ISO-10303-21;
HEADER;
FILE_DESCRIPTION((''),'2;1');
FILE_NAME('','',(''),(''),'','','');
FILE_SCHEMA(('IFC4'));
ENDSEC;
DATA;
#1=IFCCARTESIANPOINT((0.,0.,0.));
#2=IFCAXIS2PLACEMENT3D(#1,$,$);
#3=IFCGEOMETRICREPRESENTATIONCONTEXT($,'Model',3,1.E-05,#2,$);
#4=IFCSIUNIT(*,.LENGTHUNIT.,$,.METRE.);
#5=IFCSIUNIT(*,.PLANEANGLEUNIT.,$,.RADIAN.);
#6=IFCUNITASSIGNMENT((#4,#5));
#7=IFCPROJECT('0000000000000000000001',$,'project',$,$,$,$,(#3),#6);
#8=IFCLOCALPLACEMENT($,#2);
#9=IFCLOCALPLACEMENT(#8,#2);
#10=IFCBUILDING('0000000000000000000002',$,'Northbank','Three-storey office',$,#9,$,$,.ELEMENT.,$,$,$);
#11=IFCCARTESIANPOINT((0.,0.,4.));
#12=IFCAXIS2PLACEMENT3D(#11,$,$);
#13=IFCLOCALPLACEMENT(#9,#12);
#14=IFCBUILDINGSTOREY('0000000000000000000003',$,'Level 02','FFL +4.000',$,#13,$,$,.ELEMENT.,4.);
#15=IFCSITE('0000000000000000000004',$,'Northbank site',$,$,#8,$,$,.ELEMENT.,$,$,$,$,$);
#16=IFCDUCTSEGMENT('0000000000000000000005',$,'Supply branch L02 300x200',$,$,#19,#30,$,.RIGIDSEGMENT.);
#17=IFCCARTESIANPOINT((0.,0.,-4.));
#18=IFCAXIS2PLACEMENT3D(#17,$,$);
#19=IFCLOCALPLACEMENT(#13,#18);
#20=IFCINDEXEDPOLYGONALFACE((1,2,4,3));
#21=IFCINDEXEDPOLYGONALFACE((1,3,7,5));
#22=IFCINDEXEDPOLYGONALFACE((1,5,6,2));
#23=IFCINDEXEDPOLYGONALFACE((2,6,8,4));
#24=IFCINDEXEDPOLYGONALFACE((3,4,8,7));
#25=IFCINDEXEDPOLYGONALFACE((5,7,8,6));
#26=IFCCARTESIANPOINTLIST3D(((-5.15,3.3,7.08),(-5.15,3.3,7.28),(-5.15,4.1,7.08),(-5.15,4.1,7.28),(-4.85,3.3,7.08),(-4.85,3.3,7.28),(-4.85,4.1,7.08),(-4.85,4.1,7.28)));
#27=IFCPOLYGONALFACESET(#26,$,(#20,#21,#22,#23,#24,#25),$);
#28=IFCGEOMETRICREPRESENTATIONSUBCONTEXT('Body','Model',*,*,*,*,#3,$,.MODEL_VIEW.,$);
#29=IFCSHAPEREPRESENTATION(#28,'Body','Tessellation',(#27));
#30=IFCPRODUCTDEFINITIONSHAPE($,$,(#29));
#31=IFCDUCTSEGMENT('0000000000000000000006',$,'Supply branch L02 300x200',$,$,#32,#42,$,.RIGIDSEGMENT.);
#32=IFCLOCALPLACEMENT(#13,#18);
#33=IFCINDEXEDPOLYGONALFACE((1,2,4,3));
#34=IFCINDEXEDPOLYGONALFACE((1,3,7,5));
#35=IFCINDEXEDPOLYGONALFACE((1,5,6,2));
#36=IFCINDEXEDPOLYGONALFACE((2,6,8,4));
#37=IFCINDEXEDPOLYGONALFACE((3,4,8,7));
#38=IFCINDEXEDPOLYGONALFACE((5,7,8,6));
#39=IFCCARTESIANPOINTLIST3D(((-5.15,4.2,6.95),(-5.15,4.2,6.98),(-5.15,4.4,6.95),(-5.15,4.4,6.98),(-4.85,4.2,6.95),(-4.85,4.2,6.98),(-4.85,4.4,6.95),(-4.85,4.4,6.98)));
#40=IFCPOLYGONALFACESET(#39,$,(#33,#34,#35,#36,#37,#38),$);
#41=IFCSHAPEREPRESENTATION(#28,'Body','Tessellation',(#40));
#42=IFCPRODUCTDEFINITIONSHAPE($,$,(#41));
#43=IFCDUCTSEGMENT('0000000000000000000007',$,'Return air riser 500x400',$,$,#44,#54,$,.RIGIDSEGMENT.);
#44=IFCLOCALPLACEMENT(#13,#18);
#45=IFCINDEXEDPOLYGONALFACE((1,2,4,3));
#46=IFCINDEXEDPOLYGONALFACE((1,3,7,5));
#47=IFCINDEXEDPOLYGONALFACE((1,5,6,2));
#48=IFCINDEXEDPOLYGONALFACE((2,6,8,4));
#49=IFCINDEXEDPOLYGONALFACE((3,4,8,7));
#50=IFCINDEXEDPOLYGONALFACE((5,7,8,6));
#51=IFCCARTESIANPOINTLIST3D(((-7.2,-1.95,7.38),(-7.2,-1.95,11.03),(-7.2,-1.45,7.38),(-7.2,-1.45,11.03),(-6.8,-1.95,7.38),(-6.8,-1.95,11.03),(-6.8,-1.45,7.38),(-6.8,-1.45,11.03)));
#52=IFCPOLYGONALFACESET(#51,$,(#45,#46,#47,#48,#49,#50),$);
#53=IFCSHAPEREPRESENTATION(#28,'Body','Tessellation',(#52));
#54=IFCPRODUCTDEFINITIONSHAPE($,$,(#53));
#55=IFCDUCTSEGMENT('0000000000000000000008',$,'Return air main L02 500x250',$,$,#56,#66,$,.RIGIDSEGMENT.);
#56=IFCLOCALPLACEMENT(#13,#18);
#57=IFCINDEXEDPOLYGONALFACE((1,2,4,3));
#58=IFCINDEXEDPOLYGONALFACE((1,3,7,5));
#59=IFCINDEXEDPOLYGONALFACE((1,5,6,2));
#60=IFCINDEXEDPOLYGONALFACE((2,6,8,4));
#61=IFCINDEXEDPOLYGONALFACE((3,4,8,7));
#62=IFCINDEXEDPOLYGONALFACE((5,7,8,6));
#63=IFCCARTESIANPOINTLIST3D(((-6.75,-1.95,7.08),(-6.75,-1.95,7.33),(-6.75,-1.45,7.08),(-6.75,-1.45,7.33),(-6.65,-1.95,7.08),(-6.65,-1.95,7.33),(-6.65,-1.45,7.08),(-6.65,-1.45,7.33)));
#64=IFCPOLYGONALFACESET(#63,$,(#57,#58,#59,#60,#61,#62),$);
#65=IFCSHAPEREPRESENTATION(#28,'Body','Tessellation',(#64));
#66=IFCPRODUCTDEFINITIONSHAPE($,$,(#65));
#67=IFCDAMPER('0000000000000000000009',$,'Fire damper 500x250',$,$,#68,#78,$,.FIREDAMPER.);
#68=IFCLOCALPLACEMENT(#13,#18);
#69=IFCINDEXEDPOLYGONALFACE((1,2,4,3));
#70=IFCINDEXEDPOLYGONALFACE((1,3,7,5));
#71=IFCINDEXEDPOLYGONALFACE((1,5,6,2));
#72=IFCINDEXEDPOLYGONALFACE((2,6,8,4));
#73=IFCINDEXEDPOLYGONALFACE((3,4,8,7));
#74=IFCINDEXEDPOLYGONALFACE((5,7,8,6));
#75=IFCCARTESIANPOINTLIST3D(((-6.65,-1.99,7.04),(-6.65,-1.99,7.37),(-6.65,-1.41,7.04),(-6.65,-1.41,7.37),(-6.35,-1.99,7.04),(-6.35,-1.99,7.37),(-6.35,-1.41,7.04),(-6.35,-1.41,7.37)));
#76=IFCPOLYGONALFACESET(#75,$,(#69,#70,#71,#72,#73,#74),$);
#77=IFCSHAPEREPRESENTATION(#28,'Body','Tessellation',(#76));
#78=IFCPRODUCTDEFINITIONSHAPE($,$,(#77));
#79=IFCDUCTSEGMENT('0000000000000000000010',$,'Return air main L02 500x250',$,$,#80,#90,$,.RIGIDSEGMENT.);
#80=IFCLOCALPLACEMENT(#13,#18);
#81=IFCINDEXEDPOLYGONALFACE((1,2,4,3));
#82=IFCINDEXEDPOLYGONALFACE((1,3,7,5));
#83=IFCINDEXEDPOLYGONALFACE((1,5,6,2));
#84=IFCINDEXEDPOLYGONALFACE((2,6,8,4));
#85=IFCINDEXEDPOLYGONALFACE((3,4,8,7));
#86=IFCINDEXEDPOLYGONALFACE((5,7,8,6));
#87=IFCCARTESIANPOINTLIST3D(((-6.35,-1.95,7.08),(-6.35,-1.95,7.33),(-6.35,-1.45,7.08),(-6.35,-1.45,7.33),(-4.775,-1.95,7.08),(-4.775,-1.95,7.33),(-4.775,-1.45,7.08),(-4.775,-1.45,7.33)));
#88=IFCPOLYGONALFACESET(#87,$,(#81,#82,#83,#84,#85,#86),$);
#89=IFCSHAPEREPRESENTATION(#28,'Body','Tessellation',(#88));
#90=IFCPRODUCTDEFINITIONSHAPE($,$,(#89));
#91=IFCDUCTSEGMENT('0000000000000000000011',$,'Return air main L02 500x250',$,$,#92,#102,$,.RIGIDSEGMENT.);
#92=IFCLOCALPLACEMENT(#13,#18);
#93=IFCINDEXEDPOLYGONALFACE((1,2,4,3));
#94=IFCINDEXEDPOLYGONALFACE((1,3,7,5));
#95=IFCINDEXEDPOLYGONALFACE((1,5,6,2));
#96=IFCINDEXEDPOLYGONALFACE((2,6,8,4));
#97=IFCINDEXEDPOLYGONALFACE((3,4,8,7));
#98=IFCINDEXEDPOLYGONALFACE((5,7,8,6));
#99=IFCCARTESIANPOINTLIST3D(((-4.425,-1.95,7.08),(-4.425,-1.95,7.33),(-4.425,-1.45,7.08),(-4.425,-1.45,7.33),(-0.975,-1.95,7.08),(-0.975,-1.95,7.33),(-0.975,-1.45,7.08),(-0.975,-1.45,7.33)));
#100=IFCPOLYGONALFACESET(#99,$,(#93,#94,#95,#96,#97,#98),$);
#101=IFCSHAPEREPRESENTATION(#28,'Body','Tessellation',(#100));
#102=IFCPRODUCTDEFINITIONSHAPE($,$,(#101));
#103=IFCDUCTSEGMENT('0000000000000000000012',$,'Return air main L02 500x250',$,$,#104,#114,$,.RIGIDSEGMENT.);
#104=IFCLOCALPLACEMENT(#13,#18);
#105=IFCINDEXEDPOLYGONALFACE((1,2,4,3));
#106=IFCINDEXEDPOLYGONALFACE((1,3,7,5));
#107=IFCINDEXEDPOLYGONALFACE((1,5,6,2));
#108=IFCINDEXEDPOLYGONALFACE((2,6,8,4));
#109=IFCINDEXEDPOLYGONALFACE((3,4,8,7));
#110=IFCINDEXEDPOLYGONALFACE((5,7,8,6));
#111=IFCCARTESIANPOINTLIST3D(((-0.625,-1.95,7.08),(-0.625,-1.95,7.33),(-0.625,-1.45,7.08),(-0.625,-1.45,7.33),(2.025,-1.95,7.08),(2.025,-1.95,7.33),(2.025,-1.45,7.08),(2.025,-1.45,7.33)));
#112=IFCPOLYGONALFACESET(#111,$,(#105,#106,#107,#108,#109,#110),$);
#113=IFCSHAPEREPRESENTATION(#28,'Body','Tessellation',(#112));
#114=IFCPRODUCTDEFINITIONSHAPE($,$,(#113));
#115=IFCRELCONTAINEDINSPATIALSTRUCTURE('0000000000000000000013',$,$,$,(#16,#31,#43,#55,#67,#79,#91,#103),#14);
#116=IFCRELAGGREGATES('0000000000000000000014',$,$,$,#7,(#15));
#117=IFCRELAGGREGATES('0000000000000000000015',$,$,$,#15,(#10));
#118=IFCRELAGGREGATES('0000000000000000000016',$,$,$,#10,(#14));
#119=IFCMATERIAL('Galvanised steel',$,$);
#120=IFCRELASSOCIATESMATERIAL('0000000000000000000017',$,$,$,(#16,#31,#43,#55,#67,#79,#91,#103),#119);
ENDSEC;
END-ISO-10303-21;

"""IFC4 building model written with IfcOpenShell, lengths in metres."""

from ifc_helpers import new_model, si_unit, frame, origin, place, context, subcontext, project, spatial, rectangle, extrude, material, element, save


model = new_model("IFC4")

# Units and contexts
model_context = context("Model", 3, precision=1e-05, world=origin())
body_context = subcontext(model_context, "Body", "Model", "MODEL_VIEW")
ifc_project = project(units=[si_unit("LENGTHUNIT", "METRE"), si_unit("PLANEANGLEUNIT", "RADIAN")], contexts=[model_context])

# Site, building, storey
site_placement = place(None, origin())
site = spatial("IfcSite", under=ifc_project, at=site_placement, Name="Northbank site", CompositionType="ELEMENT")
building_placement = place(site_placement, origin())
building = spatial("IfcBuilding", under=site, at=building_placement, Name="Northbank", Description="Three-storey office", CompositionType="ELEMENT")
storey_placement = place(building_placement, frame((0.0, 0.0, 4.0)))
storey = spatial("IfcBuildingStorey", under=building, at=storey_placement, Name="Level 02", Description="FFL +4.000", CompositionType="ELEMENT", Elevation=4.0)

# Shared definitions
ifc_material_1 = material(Name="Galvanised steel")

# Duct segments
duct_segment_1_placement = place(storey_placement, frame((0.0, 0.0, -4.0)))
element("IfcDuctSegment", 1, at=duct_segment_1_placement, inside=storey, material=ifc_material_1, Name="Supply branch L02 300x200", PredefinedType="RIGIDSEGMENT", context=body_context, shape_type="SweptSolid", body=[
    extrude(rectangle(XDim=0.3, YDim=0.2), frame((-5.0, 3.3, 7.18), z_axis=(0.0, 1.0, 0.0), x_axis=(-1.0, 0.0, 0.0)), (0.0, 0.0, 1.0), 0.8),
])
duct_segment_2_placement = place(storey_placement, frame((0.0, 0.0, -4.0)))
element("IfcDuctSegment", 2, at=duct_segment_2_placement, inside=storey, material=ifc_material_1, Name="Supply branch L02 300x200", PredefinedType="RIGIDSEGMENT", context=body_context, shape_type="SweptSolid", body=[
    extrude(rectangle(XDim=0.3, YDim=0.2), frame((-5.0, 4.3, 6.98), z_axis=(0.0, 0.0, -1.0), x_axis=(-1.0, 0.0, 0.0)), (0.0, 0.0, 1.0), 0.03),
])

# Duct segments
duct_segment_3_placement = place(storey_placement, frame((0.0, 0.0, -4.0)))
element("IfcDuctSegment", 3, at=duct_segment_3_placement, inside=storey, material=ifc_material_1, Name="Return air riser 500x400", PredefinedType="RIGIDSEGMENT", context=body_context, shape_type="SweptSolid", body=[
    extrude(rectangle(XDim=0.5, YDim=0.4), frame((-7.0, -1.7, 11.03), z_axis=(0.0, 0.0, -1.0), x_axis=(0.0, -1.0, 0.0)), (0.0, 0.0, 1.0), 3.65),
])
duct_segment_4_placement = place(storey_placement, frame((0.0, 0.0, -4.0)))
element("IfcDuctSegment", 4, at=duct_segment_4_placement, inside=storey, material=ifc_material_1, Name="Return air main L02 500x250", PredefinedType="RIGIDSEGMENT", context=body_context, shape_type="SweptSolid", body=[
    extrude(rectangle(XDim=0.5, YDim=0.25), frame((-6.75, -1.7, 7.205), z_axis=(1.0, 0.0, 0.0), x_axis=(0.0, 1.0, 0.0)), (0.0, 0.0, 1.0), 0.1),
])

# Damper
damper_1_placement = place(storey_placement, frame((0.0, 0.0, -4.0)))
element("IfcDamper", 5, at=damper_1_placement, inside=storey, material=ifc_material_1, Name="Fire damper 500x250", PredefinedType="FIREDAMPER", context=body_context, shape_type="SweptSolid", body=[
    extrude(rectangle(XDim=0.58, YDim=0.33), frame((-6.65, -1.7, 7.205), z_axis=(1.0, 0.0, 0.0), x_axis=(0.0, 1.0, 0.0)), (0.0, 0.0, 1.0), 0.3),
])

# Duct segment
duct_segment_5_placement = place(storey_placement, frame((0.0, 0.0, -4.0)))
element("IfcDuctSegment", 6, at=duct_segment_5_placement, inside=storey, material=ifc_material_1, Name="Return air main L02 500x250", PredefinedType="RIGIDSEGMENT", context=body_context, shape_type="SweptSolid", body=[
    extrude(rectangle(XDim=0.5, YDim=0.25), frame((-6.35, -1.7, 7.205), z_axis=(1.0, 0.0, 0.0), x_axis=(0.0, 1.0, 0.0)), (0.0, 0.0, 1.0), 1.575),
])

# Duct segment
duct_segment_6_placement = place(storey_placement, frame((0.0, 0.0, -4.0)))
element("IfcDuctSegment", 7, at=duct_segment_6_placement, inside=storey, material=ifc_material_1, Name="Return air main L02 500x250", PredefinedType="RIGIDSEGMENT", context=body_context, shape_type="SweptSolid", body=[
    extrude(rectangle(XDim=0.5, YDim=0.25), frame((-4.425, -1.7, 7.205), z_axis=(1.0, 0.0, 0.0), x_axis=(0.0, 1.0, 0.0)), (0.0, 0.0, 1.0), 3.45),
])

# Duct segment
duct_segment_7_placement = place(storey_placement, frame((0.0, 0.0, -4.0)))
element("IfcDuctSegment", 8, at=duct_segment_7_placement, inside=storey, material=ifc_material_1, Name="Return air main L02 500x250", PredefinedType="RIGIDSEGMENT", context=body_context, shape_type="SweptSolid", body=[
    extrude(rectangle(XDim=0.5, YDim=0.25), frame((-0.625, -1.7, 7.205), z_axis=(1.0, 0.0, 0.0), x_axis=(0.0, 1.0, 0.0)), (0.0, 0.0, 1.0), 2.65),
])

save(model, "model.ifc")
